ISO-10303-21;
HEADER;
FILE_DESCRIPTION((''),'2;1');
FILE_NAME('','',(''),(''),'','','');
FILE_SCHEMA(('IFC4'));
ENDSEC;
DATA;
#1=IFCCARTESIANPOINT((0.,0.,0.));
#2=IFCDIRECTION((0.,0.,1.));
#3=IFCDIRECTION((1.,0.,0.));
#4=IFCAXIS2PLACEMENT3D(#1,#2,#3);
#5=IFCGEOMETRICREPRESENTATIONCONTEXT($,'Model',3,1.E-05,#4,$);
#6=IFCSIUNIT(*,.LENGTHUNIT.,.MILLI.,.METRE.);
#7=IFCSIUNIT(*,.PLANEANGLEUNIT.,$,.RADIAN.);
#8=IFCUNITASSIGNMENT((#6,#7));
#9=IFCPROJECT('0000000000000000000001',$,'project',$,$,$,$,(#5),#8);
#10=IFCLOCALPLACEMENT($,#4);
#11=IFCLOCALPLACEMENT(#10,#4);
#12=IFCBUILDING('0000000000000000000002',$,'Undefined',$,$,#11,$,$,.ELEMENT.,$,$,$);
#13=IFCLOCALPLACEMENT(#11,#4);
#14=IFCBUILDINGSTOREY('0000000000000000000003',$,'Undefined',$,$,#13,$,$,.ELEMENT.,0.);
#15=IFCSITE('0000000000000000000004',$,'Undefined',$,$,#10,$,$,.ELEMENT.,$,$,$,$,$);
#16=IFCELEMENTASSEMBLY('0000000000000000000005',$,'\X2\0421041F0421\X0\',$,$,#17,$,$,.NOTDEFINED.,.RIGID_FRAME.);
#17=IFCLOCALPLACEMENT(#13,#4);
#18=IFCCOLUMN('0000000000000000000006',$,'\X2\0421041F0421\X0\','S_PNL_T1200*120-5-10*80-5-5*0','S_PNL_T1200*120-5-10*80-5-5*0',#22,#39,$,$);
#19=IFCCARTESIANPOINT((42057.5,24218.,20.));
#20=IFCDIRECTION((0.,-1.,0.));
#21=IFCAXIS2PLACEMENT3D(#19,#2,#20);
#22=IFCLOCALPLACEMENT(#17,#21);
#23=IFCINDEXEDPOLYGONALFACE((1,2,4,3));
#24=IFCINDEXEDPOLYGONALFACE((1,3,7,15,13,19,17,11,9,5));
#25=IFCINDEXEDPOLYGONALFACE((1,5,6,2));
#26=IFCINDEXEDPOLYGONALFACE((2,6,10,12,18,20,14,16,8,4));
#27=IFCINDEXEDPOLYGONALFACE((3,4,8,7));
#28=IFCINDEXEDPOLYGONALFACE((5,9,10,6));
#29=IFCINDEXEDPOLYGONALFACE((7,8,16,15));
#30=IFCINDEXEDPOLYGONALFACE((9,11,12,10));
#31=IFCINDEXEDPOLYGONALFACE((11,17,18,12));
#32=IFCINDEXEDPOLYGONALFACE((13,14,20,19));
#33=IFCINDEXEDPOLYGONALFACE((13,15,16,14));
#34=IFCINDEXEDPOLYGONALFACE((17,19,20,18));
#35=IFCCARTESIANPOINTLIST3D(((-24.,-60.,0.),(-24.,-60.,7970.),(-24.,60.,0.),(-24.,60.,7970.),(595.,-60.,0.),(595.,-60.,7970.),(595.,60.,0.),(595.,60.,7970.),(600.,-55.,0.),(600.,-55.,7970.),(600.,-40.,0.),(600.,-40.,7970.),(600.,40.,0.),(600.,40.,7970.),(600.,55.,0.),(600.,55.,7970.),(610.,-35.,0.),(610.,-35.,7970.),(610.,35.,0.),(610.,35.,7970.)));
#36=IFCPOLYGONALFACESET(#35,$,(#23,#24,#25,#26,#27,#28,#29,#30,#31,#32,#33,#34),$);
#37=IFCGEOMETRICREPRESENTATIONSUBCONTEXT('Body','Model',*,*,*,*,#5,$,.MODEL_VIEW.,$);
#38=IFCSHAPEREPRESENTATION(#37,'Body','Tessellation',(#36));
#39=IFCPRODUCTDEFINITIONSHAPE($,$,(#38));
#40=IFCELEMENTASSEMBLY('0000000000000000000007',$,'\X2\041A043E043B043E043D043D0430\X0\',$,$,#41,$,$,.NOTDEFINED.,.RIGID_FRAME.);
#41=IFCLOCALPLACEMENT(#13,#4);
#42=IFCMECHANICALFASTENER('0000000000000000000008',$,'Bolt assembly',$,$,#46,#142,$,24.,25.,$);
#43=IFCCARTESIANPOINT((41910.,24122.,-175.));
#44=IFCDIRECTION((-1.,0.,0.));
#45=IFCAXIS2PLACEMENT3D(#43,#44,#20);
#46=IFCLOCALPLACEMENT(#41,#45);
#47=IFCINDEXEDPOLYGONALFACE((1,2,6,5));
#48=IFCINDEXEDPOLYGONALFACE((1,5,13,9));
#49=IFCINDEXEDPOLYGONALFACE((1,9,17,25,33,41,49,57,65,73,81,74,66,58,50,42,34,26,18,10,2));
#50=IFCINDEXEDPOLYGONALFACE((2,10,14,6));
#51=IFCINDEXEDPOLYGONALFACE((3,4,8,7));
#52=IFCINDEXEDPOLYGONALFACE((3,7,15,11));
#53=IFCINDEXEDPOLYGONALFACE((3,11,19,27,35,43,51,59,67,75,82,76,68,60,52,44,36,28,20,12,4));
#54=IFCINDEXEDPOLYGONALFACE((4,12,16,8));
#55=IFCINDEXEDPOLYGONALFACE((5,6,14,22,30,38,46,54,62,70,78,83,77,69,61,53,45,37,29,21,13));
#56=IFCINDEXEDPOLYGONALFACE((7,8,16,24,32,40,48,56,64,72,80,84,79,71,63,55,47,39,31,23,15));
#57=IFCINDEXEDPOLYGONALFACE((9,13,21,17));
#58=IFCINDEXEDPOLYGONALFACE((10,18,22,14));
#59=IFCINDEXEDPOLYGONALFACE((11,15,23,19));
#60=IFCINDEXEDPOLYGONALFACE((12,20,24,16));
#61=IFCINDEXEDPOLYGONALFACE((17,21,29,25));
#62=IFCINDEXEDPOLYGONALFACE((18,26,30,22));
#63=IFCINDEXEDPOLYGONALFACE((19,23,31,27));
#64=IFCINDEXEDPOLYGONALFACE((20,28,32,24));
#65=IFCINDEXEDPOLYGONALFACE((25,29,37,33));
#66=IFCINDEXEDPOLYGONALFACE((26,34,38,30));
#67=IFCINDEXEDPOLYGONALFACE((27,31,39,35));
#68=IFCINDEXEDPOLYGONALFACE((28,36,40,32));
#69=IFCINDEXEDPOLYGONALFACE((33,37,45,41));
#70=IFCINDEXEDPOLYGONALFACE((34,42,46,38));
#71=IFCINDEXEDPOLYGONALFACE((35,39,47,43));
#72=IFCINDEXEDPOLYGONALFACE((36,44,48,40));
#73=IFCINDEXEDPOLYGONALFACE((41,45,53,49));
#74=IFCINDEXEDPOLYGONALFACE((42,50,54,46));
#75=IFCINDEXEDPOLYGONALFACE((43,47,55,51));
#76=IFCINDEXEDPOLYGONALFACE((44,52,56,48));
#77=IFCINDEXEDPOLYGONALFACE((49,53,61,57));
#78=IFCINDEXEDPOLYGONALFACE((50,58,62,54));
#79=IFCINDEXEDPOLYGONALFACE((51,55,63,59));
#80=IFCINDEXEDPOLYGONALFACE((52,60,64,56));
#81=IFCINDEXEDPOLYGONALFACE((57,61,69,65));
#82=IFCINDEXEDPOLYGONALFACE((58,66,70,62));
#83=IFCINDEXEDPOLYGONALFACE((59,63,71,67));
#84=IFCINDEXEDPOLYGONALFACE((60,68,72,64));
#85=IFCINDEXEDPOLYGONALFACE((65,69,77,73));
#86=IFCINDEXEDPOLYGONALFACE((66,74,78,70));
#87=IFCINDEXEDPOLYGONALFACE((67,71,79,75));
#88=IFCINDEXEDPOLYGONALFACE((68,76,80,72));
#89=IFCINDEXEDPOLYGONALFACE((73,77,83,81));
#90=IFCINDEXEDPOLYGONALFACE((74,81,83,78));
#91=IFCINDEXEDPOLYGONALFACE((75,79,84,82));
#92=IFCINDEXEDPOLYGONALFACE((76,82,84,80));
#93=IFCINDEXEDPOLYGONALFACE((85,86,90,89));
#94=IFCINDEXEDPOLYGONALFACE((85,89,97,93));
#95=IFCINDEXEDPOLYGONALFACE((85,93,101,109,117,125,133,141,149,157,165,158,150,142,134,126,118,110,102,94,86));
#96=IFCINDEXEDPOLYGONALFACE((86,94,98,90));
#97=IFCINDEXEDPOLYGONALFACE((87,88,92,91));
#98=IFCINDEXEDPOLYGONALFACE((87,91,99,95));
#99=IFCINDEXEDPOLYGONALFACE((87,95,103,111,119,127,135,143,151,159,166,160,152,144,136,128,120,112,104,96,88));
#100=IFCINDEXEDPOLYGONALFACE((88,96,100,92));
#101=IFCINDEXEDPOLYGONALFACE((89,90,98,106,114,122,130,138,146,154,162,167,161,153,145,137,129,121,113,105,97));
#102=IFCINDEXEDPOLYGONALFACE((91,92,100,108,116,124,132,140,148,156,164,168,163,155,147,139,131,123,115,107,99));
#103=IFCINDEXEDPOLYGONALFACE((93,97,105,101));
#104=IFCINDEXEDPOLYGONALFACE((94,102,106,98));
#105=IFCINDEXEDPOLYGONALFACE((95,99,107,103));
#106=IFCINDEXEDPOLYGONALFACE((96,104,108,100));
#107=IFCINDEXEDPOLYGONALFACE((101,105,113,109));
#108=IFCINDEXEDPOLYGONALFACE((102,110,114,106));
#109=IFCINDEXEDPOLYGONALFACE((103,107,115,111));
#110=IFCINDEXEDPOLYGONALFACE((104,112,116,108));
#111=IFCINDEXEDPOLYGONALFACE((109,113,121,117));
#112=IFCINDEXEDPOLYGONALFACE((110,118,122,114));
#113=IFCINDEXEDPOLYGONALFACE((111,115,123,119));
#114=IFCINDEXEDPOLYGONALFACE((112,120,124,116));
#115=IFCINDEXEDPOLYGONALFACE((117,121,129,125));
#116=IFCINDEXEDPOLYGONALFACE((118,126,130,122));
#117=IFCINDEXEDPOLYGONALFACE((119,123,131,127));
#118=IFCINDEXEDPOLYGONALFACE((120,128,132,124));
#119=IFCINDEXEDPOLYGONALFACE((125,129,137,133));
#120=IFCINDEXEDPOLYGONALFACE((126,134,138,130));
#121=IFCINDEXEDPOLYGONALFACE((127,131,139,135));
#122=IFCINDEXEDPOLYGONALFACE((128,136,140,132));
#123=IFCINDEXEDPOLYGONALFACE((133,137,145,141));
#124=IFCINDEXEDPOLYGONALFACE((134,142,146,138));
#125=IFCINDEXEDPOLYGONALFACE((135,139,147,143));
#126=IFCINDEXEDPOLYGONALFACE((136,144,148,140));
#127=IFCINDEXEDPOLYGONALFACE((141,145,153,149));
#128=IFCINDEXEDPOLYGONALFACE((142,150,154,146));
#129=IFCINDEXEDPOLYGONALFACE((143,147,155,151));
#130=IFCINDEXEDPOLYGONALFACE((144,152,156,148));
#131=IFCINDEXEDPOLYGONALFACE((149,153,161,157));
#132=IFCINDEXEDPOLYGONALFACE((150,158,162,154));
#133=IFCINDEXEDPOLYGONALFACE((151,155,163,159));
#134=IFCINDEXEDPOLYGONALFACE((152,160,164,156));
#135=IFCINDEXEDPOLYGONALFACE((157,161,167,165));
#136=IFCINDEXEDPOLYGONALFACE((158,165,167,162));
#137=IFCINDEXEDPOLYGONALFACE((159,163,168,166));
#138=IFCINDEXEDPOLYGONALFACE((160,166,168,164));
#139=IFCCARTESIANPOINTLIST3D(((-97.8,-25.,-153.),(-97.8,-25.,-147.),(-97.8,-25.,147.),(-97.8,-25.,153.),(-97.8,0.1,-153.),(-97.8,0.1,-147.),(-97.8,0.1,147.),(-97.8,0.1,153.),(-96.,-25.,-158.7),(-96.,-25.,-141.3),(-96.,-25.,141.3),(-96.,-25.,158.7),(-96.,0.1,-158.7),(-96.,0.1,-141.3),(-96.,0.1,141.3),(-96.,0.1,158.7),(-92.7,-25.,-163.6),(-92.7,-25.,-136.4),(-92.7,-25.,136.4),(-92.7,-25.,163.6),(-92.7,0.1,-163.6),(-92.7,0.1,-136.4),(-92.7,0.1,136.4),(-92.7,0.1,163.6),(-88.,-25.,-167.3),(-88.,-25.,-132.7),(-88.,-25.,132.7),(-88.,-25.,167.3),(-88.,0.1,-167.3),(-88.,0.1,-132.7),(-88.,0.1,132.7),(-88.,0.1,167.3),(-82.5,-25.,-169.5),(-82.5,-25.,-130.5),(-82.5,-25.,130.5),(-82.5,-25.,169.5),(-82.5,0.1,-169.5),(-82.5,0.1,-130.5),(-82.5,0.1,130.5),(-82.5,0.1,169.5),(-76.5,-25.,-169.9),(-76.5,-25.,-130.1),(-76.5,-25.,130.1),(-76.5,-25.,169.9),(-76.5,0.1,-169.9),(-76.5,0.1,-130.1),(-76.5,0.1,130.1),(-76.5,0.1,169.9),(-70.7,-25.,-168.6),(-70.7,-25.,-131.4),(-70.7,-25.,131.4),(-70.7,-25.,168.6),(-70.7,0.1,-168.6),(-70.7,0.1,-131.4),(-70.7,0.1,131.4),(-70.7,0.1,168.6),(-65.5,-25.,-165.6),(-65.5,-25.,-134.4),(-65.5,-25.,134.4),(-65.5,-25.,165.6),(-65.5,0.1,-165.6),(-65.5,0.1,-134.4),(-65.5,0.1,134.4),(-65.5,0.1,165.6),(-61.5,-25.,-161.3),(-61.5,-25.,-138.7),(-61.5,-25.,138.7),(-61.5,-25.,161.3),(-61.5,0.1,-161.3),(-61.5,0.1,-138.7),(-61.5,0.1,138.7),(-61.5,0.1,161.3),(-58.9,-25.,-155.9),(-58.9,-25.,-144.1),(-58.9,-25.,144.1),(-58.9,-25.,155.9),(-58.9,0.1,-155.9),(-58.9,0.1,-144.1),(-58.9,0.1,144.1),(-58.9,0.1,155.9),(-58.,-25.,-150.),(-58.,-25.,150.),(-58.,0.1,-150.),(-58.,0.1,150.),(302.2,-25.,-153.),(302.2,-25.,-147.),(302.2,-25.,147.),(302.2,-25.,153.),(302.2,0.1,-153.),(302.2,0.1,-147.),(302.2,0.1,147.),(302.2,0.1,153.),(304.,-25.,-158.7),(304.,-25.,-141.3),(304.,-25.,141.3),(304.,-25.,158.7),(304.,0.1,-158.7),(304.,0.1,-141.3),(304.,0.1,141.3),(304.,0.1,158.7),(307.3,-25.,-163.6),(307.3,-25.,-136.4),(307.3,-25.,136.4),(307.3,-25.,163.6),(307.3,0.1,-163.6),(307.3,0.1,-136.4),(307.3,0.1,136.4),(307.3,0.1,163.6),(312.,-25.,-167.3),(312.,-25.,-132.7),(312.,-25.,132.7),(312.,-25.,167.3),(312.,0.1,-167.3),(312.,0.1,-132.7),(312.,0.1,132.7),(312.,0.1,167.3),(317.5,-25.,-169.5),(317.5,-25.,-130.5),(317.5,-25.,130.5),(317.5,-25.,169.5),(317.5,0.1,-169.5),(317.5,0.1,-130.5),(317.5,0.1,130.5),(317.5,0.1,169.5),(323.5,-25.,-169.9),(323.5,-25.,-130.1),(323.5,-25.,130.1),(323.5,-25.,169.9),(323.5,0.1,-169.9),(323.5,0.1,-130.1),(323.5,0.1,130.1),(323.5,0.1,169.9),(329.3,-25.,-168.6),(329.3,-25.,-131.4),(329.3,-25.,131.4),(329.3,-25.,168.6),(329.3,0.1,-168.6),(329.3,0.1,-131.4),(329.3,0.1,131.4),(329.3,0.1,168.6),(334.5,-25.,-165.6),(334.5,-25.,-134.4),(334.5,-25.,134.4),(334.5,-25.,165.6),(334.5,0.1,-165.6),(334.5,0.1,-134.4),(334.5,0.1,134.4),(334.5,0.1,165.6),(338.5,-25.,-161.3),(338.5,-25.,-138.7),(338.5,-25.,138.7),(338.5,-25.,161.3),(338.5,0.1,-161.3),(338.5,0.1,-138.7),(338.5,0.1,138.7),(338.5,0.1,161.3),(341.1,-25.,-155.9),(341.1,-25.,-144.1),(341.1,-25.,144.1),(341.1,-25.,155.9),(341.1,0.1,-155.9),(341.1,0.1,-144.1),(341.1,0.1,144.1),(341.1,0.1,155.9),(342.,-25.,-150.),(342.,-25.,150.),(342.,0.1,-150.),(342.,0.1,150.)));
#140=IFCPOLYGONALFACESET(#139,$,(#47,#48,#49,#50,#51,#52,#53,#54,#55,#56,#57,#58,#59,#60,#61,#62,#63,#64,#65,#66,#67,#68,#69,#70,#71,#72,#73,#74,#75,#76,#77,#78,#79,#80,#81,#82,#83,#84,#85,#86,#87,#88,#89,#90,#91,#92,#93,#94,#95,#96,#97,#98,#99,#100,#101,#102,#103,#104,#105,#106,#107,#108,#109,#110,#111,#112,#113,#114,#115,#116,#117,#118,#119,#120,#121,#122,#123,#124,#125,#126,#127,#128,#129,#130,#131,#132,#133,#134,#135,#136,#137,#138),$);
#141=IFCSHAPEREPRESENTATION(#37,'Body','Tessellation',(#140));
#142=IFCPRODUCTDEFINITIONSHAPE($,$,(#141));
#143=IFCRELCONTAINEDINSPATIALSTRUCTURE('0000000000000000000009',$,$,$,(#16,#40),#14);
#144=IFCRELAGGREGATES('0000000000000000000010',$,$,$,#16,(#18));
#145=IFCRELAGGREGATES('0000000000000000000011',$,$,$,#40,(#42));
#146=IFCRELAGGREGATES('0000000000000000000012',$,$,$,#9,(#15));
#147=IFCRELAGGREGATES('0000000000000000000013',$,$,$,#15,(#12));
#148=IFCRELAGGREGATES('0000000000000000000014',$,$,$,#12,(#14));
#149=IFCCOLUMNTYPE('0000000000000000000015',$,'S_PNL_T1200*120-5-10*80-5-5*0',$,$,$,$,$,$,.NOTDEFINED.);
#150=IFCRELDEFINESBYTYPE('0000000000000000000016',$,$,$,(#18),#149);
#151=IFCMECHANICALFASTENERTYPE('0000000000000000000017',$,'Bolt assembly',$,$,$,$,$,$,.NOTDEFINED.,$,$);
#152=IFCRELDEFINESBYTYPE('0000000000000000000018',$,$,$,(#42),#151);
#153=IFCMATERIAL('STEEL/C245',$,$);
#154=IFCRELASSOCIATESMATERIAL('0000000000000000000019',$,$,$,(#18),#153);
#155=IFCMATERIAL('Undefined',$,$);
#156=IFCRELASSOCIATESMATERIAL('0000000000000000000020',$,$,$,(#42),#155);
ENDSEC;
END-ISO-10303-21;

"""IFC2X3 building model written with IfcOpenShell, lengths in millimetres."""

from ifc_helpers import new_model, si_unit, frame, origin_with_axes, origin_2d_with_axis, place, context, subcontext, project, spatial, polyline, rectangle, circle, outline, extrude, boolean, source, transform, mapped, material, type_object, element, aggregate, save


model = new_model("IFC2X3")

# Units and contexts
model_context = context("Model", 3, precision=1e-05, world=origin_with_axes())
body_context = subcontext(model_context, "Body", "Model", "MODEL_VIEW")
ifc_project = project(units=[si_unit("LENGTHUNIT", "METRE", prefix="MILLI"), si_unit("PLANEANGLEUNIT", "RADIAN")], contexts=[model_context])

# Site, building, storey
site_placement = place(None, origin_with_axes())
site = spatial("IfcSite", under=ifc_project, at=site_placement, Name="Undefined", CompositionType="ELEMENT")
building_placement = place(site_placement, origin_with_axes())
building = spatial("IfcBuilding", under=site, at=building_placement, Name="Undefined", CompositionType="ELEMENT")
storey_placement = place(building_placement, origin_with_axes())
storey = spatial("IfcBuildingStorey", under=building, at=storey_placement, Name="Undefined", CompositionType="ELEMENT", Elevation=0.0)

# Element assembly, column
assembly_1_placement = place(storey_placement, origin_with_axes())
assembly_1 = element("IfcElementAssembly", 1, at=assembly_1_placement, inside=storey, Name="СПС", AssemblyPlace="NOTDEFINED", PredefinedType="RIGID_FRAME")
ifc_material_1 = material(Name="STEEL/C245")
column_type_1 = type_object("IfcColumnType", Name="S_PNL_T1200*120-5-10*80-5-5*0", PredefinedType="NOTDEFINED")
column_1_placement = place(assembly_1_placement, frame((42057.5, 24218.0, 20.0), z_axis=(0.0, 0.0, 1.0), x_axis=(0.0, -1.0, 0.0)))
column_1 = element("IfcColumn", 2, at=column_1_placement, type_object=column_type_1, material=ifc_material_1, Name="СПС", Description="S_PNL_T1200*120-5-10*80-5-5*0", ObjectType="S_PNL_T1200*120-5-10*80-5-5*0", context=body_context, shape_type="CSG", body=[
    boolean("DIFFERENCE", extrude(outline(polyline([(-40.0, -590.0), (-45.0, -600.0), (-55.0, -600.0), (-60.0, -595.0), (-60.0, 595.0), (-55.0, 600.0), (-40.0, 600.0), (-35.0, 610.0), (35.0, 610.0), (40.0, 600.0), (55.0, 600.0), (60.0, 595.0), (60.0, -595.0), (55.0, -600.0), (45.0, -600.0), (40.0, -590.0), (-40.0, -590.0)])), frame((0.0, 0.0, 7970.0), z_axis=(0.0, 0.0, -1.0), x_axis=(0.0, 1.0, 0.0)), (0.0, 0.0, 1.0), 7970.0), extrude(rectangle(XDim=300.0, YDim=700.0, at=origin_2d_with_axis()), frame((-374.0, -72.5, -30.0), z_axis=(0.0, 0.0, 1.0), x_axis=(0.0, -1.0, 0.0)), (0.0, 0.0, 1.0), 8000.0)),
])
aggregate(assembly_1, [column_1])

# Element assembly
assembly_2_placement = place(storey_placement, origin_with_axes())
assembly_2 = element("IfcElementAssembly", 3, at=assembly_2_placement, inside=storey, Name="Колонна", AssemblyPlace="NOTDEFINED", PredefinedType="RIGID_FRAME")

# Shared definitions
ifc_material_2 = material(Name="Undefined")
mechanical_fastener_type = type_object("IfcMechanicalFastenerType", Name="Bolt assembly")

# Mechanical fastener
shared_shape_1 = source(origin_with_axes(), body_context, "Body", "SweptSolid", [
    extrude(circle(Radius=20.0, at=origin_2d_with_axis()), frame((0.0, -25.0, 0.0), z_axis=(0.0, 1.0, 0.0), x_axis=(1.0, 0.0, 0.0)), (0.0, 0.0, 1.0), 25.1),
])
mechanical_fastener_1_placement = place(assembly_2_placement, frame((41910.0, 24122.0, -175.0), z_axis=(-1.0, 0.0, 0.0), x_axis=(0.0, -1.0, 0.0)))
mechanical_fastener_1 = element("IfcMechanicalFastener", 4, at=mechanical_fastener_1_placement, type_object=mechanical_fastener_type, material=ifc_material_2, Name="Bolt assembly", NominalDiameter=24.0, NominalLength=25.0, context=body_context, shape_type="MappedRepresentation", body=[
    mapped(shared_shape_1, transform((-78.0, 0.0, -150.0))),
    mapped(shared_shape_1, transform((-78.0, 0.0, 150.0))),
    mapped(shared_shape_1, transform((322.0, 0.0, -150.0))),
    mapped(shared_shape_1, transform((322.0, 0.0, 150.0))),
])
aggregate(assembly_2, [mechanical_fastener_1])

save(model, "model.ifc")
